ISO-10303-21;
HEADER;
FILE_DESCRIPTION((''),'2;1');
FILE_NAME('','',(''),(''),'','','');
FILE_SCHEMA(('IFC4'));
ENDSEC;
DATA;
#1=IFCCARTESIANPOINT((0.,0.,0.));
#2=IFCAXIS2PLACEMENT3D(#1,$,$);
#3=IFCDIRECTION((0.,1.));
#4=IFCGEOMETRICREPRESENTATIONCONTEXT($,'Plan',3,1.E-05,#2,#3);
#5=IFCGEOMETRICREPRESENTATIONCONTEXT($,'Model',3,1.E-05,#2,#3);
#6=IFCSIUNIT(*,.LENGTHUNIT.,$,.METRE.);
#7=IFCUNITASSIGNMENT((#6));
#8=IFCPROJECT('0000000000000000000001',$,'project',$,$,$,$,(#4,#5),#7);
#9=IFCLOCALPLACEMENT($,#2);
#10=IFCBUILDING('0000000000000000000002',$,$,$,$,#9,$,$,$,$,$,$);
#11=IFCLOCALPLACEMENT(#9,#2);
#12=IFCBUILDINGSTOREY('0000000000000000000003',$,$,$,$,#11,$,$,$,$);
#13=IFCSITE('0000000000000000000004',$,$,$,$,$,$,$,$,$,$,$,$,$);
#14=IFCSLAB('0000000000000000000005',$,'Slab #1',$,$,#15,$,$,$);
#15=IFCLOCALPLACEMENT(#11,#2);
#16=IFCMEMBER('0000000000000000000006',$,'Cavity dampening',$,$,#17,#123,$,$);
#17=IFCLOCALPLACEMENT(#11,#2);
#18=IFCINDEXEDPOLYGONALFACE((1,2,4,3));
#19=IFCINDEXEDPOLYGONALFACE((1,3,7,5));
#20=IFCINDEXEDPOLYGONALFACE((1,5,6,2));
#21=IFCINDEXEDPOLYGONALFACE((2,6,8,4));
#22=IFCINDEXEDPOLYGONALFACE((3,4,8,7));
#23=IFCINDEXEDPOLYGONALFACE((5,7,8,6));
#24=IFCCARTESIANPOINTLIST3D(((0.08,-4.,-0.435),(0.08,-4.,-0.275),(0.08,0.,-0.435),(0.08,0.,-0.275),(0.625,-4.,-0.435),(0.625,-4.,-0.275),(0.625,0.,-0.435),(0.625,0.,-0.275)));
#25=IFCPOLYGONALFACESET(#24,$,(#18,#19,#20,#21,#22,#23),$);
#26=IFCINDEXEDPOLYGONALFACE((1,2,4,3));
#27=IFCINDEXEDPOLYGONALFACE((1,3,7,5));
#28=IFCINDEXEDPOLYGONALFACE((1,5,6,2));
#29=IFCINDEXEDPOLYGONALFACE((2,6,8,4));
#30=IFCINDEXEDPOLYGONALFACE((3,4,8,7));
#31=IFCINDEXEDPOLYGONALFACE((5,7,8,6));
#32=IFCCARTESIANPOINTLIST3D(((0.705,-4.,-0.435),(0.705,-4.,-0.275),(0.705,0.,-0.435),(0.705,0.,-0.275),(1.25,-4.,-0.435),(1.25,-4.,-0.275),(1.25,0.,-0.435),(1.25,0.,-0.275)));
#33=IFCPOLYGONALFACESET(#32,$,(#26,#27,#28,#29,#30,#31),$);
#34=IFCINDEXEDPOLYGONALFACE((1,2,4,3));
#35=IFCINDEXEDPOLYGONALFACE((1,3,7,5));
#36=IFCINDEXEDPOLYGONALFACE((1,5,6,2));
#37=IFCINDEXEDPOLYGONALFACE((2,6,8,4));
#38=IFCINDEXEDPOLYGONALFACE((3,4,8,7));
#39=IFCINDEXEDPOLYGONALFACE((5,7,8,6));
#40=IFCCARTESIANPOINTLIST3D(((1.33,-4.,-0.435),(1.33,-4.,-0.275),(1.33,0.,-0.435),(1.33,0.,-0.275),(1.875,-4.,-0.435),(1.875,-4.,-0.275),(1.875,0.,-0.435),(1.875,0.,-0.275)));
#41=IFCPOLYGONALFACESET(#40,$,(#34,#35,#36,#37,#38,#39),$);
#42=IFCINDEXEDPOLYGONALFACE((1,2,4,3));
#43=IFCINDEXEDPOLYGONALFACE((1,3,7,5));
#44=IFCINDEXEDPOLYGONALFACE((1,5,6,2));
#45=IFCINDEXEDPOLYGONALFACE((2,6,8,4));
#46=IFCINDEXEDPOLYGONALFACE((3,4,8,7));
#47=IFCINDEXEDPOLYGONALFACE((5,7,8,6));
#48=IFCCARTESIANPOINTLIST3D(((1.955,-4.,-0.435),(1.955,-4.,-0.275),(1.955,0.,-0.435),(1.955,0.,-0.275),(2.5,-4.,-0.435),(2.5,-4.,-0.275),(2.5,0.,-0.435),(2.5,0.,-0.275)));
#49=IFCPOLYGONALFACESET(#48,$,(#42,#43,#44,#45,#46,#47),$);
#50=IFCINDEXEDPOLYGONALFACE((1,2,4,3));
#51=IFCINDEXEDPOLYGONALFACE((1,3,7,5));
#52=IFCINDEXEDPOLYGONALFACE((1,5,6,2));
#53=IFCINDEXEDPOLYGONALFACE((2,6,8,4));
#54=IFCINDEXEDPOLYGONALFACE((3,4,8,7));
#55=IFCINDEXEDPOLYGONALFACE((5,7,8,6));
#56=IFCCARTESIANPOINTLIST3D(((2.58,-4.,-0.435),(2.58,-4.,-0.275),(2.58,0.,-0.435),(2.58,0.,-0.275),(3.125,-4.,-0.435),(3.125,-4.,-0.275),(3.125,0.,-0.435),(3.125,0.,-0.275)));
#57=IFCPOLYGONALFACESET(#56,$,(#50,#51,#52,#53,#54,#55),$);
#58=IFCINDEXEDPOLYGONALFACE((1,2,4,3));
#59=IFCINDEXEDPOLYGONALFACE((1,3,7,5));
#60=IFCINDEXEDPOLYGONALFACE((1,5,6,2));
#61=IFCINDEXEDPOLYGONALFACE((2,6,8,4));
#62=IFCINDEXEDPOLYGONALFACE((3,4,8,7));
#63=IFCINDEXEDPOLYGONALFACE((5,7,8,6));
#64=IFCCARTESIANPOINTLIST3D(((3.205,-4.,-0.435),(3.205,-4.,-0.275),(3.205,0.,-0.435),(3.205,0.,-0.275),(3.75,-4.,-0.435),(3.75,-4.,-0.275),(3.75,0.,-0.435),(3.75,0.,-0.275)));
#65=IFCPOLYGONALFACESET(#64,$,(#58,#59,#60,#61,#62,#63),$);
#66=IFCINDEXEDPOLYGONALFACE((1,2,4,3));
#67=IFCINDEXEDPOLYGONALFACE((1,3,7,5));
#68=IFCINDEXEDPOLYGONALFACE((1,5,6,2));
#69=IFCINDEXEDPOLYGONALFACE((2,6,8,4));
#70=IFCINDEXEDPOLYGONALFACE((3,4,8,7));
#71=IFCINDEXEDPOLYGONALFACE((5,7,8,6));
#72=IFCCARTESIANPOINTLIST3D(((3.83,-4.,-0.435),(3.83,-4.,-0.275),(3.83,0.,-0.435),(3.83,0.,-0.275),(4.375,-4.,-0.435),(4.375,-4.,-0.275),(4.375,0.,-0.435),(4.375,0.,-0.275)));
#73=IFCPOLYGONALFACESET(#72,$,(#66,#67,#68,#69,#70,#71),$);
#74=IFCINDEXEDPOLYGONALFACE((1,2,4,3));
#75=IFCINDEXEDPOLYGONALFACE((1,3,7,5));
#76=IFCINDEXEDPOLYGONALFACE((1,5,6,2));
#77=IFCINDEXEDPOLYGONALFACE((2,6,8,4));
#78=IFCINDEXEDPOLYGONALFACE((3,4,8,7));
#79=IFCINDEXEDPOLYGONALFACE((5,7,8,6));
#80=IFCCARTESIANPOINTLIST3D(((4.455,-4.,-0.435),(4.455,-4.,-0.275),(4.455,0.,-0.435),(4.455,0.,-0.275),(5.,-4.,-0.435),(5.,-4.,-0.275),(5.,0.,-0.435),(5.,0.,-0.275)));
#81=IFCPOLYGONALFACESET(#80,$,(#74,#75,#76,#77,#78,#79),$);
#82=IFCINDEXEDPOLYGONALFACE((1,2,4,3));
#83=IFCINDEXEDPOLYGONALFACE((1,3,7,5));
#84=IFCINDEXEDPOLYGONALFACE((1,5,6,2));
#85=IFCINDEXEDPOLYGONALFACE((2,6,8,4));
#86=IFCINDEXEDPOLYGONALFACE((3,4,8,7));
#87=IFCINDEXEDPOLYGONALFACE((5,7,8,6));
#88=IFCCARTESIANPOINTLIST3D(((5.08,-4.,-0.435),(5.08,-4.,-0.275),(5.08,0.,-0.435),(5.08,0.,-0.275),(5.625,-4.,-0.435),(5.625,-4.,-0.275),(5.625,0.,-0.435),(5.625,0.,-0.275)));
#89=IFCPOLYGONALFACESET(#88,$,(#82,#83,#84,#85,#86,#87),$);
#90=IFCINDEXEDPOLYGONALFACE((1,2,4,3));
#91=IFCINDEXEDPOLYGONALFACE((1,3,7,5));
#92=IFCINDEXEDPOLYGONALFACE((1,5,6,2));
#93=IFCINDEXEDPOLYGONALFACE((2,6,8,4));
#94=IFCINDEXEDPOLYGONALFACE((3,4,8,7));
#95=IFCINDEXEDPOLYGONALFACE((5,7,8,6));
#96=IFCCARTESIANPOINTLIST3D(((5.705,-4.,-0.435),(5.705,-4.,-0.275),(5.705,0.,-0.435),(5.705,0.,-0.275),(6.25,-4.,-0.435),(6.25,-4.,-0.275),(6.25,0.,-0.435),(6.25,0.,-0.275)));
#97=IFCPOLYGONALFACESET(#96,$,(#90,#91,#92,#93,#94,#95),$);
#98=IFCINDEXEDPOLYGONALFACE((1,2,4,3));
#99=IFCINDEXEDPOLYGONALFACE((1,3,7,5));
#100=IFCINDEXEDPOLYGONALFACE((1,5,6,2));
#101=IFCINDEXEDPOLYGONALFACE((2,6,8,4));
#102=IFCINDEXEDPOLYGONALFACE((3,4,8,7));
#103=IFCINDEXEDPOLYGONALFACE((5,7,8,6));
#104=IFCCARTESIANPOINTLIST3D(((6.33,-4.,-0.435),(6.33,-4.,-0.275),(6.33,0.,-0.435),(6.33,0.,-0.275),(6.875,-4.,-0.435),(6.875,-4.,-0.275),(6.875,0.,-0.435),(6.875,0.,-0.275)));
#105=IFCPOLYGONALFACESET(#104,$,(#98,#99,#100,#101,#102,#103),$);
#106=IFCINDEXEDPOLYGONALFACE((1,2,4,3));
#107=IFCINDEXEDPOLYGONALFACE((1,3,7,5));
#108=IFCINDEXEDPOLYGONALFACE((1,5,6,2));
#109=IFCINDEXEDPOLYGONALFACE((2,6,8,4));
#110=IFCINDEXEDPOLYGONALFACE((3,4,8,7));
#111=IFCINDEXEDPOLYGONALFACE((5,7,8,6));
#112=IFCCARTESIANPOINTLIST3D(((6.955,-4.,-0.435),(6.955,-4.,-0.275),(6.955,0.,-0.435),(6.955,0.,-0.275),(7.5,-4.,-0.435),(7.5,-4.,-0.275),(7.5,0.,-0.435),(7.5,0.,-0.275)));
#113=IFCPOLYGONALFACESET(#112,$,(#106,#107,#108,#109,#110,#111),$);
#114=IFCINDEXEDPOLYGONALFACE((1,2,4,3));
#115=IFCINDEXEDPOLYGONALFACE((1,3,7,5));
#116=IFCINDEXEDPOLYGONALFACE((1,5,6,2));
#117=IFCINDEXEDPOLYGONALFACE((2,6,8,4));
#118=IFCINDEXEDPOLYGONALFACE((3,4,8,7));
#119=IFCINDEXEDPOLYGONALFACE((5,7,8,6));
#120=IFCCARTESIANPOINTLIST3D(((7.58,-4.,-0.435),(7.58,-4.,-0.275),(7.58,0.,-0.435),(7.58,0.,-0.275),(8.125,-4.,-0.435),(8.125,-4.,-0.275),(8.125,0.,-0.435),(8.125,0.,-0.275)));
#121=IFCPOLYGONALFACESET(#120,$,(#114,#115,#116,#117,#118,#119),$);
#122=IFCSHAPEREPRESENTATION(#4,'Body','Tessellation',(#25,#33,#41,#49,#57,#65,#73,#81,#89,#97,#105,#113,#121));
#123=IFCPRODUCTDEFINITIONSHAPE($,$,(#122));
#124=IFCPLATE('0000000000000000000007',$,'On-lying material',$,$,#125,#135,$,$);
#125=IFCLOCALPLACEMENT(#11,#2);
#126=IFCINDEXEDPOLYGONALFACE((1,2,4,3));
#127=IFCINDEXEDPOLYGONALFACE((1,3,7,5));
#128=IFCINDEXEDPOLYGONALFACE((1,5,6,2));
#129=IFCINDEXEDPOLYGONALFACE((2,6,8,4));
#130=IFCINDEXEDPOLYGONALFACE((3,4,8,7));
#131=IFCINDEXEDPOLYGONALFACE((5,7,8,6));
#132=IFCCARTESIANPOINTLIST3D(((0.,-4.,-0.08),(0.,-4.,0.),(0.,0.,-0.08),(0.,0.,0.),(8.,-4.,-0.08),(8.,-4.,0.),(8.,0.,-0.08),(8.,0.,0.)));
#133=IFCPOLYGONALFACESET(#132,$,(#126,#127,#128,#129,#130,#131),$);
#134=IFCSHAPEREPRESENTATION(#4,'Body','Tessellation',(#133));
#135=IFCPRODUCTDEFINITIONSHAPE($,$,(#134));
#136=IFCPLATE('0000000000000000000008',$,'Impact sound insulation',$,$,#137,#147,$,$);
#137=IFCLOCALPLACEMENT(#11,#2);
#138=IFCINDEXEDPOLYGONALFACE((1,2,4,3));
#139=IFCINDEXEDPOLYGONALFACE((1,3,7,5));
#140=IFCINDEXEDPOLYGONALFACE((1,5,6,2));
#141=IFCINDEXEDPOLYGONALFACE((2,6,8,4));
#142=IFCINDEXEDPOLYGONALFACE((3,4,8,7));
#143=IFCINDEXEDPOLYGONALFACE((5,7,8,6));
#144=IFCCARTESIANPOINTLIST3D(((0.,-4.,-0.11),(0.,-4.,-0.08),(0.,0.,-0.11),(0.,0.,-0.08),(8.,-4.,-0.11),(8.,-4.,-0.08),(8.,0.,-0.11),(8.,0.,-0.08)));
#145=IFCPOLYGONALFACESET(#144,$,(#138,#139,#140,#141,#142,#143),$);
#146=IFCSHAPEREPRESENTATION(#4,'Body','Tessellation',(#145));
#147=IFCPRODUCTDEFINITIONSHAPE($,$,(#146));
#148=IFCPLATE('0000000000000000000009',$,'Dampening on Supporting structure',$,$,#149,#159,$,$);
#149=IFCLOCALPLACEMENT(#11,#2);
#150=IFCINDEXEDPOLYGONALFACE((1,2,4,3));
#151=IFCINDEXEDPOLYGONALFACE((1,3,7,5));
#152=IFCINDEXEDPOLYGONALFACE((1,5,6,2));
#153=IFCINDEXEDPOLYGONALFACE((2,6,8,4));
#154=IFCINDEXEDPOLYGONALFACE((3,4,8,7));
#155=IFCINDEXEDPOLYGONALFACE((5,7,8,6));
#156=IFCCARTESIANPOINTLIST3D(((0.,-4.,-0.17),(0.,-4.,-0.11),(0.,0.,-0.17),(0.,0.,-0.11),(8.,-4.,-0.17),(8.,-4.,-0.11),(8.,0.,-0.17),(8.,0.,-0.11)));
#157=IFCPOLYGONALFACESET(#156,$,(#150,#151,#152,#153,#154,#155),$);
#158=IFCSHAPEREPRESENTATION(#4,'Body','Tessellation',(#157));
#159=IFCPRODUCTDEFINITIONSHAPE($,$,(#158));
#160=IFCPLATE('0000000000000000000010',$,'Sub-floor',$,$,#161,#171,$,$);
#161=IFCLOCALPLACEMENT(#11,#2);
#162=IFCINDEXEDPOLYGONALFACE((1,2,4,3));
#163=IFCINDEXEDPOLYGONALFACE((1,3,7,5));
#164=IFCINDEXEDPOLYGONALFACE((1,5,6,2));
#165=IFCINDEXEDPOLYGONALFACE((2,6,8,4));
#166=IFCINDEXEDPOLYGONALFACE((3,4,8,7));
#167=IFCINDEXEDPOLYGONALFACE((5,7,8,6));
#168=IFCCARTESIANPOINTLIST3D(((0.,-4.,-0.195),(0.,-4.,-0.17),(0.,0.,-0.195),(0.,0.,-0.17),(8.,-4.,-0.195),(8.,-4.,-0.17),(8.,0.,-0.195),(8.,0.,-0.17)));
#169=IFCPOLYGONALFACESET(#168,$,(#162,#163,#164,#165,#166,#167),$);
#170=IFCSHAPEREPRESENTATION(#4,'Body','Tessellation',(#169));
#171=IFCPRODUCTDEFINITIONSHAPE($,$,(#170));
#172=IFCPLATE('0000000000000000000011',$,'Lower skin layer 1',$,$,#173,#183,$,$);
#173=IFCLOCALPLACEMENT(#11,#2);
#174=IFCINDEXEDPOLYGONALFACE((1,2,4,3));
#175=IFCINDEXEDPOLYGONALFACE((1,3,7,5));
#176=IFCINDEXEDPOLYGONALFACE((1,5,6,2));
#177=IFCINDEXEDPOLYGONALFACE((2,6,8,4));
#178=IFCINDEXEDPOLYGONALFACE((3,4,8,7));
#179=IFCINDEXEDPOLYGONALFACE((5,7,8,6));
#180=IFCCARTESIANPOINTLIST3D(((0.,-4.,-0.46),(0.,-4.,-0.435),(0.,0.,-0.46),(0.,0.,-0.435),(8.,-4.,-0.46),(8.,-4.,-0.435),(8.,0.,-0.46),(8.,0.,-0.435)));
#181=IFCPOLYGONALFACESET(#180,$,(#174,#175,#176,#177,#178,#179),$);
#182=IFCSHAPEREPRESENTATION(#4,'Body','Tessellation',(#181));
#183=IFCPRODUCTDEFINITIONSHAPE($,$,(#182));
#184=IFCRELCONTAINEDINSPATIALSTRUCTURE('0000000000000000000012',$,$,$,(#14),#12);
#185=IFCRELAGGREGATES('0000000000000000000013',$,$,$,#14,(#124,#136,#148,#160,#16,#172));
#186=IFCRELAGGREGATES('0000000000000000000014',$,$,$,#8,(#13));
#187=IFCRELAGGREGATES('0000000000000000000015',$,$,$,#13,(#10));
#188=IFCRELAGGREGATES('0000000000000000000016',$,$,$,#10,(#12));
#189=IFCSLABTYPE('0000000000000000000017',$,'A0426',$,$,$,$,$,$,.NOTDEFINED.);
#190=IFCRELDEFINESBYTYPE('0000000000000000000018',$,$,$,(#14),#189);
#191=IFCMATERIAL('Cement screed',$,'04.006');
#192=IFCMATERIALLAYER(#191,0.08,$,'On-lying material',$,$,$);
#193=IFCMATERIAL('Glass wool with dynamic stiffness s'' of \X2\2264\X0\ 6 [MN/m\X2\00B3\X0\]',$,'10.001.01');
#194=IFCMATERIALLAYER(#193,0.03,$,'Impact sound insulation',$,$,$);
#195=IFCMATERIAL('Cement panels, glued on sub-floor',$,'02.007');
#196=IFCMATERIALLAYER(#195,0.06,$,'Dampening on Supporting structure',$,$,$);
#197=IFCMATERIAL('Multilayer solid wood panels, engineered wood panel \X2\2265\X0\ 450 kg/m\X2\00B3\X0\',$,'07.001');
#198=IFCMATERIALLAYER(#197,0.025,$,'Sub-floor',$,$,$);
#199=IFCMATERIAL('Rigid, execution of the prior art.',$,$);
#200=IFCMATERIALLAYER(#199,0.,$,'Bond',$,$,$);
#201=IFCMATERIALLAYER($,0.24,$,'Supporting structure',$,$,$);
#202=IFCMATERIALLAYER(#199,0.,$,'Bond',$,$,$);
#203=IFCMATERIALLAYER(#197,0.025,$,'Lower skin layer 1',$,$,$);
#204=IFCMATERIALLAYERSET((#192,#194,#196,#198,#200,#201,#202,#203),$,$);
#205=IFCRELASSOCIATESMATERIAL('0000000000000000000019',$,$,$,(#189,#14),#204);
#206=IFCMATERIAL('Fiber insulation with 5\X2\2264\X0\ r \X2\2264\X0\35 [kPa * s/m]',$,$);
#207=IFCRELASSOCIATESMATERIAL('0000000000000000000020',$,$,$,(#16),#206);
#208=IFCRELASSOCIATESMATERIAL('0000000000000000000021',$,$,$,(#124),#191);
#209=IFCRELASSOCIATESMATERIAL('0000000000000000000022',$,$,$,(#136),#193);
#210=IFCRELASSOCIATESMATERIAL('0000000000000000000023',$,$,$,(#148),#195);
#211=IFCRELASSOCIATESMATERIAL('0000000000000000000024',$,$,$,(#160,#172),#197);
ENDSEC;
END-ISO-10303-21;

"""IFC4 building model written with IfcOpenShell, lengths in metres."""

from ifc_helpers import new_model, si_unit, direction, frame, frame_2d, origin, origin_with_axes, place, context, project, spatial, rectangle, extrude, material, layer, layer_set, type_object, element, aggregate, save


model = new_model("IFC4")

# Units and contexts
plan_context = context("Plan", 3, precision=1e-05, world=origin(), true_north=direction((0.0, 1.0)))
model_context = context("Model", 3, precision=1e-05, world=origin(), true_north=direction((0.0, 1.0)))
ifc_project = project(units=[si_unit("LENGTHUNIT", "METRE")], contexts=[plan_context, model_context])

# Site, building, storey
site = spatial("IfcSite", under=ifc_project)
building_placement = place(None, origin())
building = spatial("IfcBuilding", under=site, at=building_placement)
storey_placement = place(building_placement, origin())
storey = spatial("IfcBuildingStorey", under=building, at=storey_placement)

# Slab, member, plates
ifc_material_1 = material(Name="Cement screed", Category="04.006")
ifc_layer_1 = layer(ifc_material_1, 0.08, Name="On-lying material")
ifc_material_2 = material(Name="Glass wool with dynamic stiffness s' of ≤ 6 [MN/m³]", Category="10.001.01")
ifc_layer_2 = layer(ifc_material_2, 0.03, Name="Impact sound insulation")
ifc_material_3 = material(Name="Cement panels, glued on sub-floor", Category="02.007")
ifc_layer_3 = layer(ifc_material_3, 0.06, Name="Dampening on Supporting structure")
ifc_material_4 = material(Name="Multilayer solid wood panels, engineered wood panel ≥ 450 kg/m³", Category="07.001")
ifc_layer_4 = layer(ifc_material_4, 0.025, Name="Sub-floor")
ifc_material_5 = material(Name="Rigid, execution of the prior art.")
ifc_layer_5 = layer(ifc_material_5, 0.0, Name="Bond")
ifc_layer_6 = layer(None, 0.24, Name="Supporting structure")
ifc_layer_7 = layer(ifc_material_5, 0.0, Name="Bond")
ifc_layer_8 = layer(ifc_material_4, 0.025, Name="Lower skin layer 1")
ifc_layer_set = layer_set([ifc_layer_1, ifc_layer_2, ifc_layer_3, ifc_layer_4, ifc_layer_5, ifc_layer_6, ifc_layer_7, ifc_layer_8])
slab_type = type_object("IfcSlabType", Name="A0426", PredefinedType="NOTDEFINED", material=ifc_layer_set)
slab_placement = place(None, frame((0.0, 0.0, 0.0), z_axis=(0.0, 0.0, -1.0), x_axis=(1.0, 0.0, 0.0)))
slab = element("IfcSlab", 1, at=slab_placement, inside=storey, type_object=slab_type, material=ifc_layer_set, Name="Slab #1")
ifc_material_6 = material(Name="Fiber insulation with 5≤ r ≤35 [kPa * s/m]")
member_1_placement = place(slab_placement, origin())
member_1 = element("IfcMember", 2, at=member_1_placement, material=ifc_material_6, Name="Cavity dampening", context=plan_context, shape_type="SweptSolid", body=[
    extrude(rectangle(XDim=0.545, YDim=0.16, at=frame_2d((0.2725, 0.08), x_axis=(1.0, 0.0))), frame((0.08, 4.0, 0.275), z_axis=(0.0, -1.0, 0.0), x_axis=(1.0, 0.0, 0.0)), (0.0, 0.0, 1.0), 4.0),
    extrude(rectangle(XDim=0.545, YDim=0.16, at=frame_2d((0.2725, 0.08), x_axis=(1.0, 0.0))), frame((0.705, 4.0, 0.275), z_axis=(0.0, -1.0, 0.0), x_axis=(1.0, 0.0, 0.0)), (0.0, 0.0, 1.0), 4.0),
    extrude(rectangle(XDim=0.545, YDim=0.16, at=frame_2d((0.2725, 0.08), x_axis=(1.0, 0.0))), frame((1.33, 4.0, 0.275), z_axis=(0.0, -1.0, 0.0), x_axis=(1.0, 0.0, 0.0)), (0.0, 0.0, 1.0), 4.0),
    extrude(rectangle(XDim=0.545, YDim=0.16, at=frame_2d((0.2725, 0.08), x_axis=(1.0, 0.0))), frame((1.955, 4.0, 0.275), z_axis=(0.0, -1.0, 0.0), x_axis=(1.0, 0.0, 0.0)), (0.0, 0.0, 1.0), 4.0),
    extrude(rectangle(XDim=0.545, YDim=0.16, at=frame_2d((0.2725, 0.08), x_axis=(1.0, 0.0))), frame((2.58, 4.0, 0.275), z_axis=(0.0, -1.0, 0.0), x_axis=(1.0, 0.0, 0.0)), (0.0, 0.0, 1.0), 4.0),
    extrude(rectangle(XDim=0.545, YDim=0.16, at=frame_2d((0.2725, 0.08), x_axis=(1.0, 0.0))), frame((3.205, 4.0, 0.275), z_axis=(0.0, -1.0, 0.0), x_axis=(1.0, 0.0, 0.0)), (0.0, 0.0, 1.0), 4.0),
    extrude(rectangle(XDim=0.545, YDim=0.16, at=frame_2d((0.2725, 0.08), x_axis=(1.0, 0.0))), frame((3.83, 4.0, 0.275), z_axis=(0.0, -1.0, 0.0), x_axis=(1.0, 0.0, 0.0)), (0.0, 0.0, 1.0), 4.0),
    extrude(rectangle(XDim=0.545, YDim=0.16, at=frame_2d((0.2725, 0.08), x_axis=(1.0, 0.0))), frame((4.455, 4.0, 0.275), z_axis=(0.0, -1.0, 0.0), x_axis=(1.0, 0.0, 0.0)), (0.0, 0.0, 1.0), 4.0),
    extrude(rectangle(XDim=0.545, YDim=0.16, at=frame_2d((0.2725, 0.08), x_axis=(1.0, 0.0))), frame((5.08, 4.0, 0.275), z_axis=(0.0, -1.0, 0.0), x_axis=(1.0, 0.0, 0.0)), (0.0, 0.0, 1.0), 4.0),
    extrude(rectangle(XDim=0.545, YDim=0.16, at=frame_2d((0.2725, 0.08), x_axis=(1.0, 0.0))), frame((5.705, 4.0, 0.275), z_axis=(0.0, -1.0, 0.0), x_axis=(1.0, 0.0, 0.0)), (0.0, 0.0, 1.0), 4.0),
    extrude(rectangle(XDim=0.545, YDim=0.16, at=frame_2d((0.2725, 0.08), x_axis=(1.0, 0.0))), frame((6.33, 4.0, 0.275), z_axis=(0.0, -1.0, 0.0), x_axis=(1.0, 0.0, 0.0)), (0.0, 0.0, 1.0), 4.0),
    extrude(rectangle(XDim=0.545, YDim=0.16, at=frame_2d((0.2725, 0.08), x_axis=(1.0, 0.0))), frame((6.955, 4.0, 0.275), z_axis=(0.0, -1.0, 0.0), x_axis=(1.0, 0.0, 0.0)), (0.0, 0.0, 1.0), 4.0),
    extrude(rectangle(XDim=0.545, YDim=0.16, at=frame_2d((0.2725, 0.08), x_axis=(1.0, 0.0))), frame((7.58, 4.0, 0.275), z_axis=(0.0, -1.0, 0.0), x_axis=(1.0, 0.0, 0.0)), (0.0, 0.0, 1.0), 4.0),
])
plate_1_placement = place(slab_placement, origin())
plate_1 = element("IfcPlate", 3, at=plate_1_placement, material=ifc_material_1, Name="On-lying material", context=plan_context, shape_type="SweptSolid", body=[
    extrude(rectangle(XDim=8.0, YDim=4.0, at=frame_2d((4.0, 2.0), x_axis=(1.0, 0.0))), origin_with_axes(), (0.0, 0.0, 1.0), 0.08),
])
plate_2_placement = place(slab_placement, origin())
plate_2 = element("IfcPlate", 4, at=plate_2_placement, material=ifc_material_2, Name="Impact sound insulation", context=plan_context, shape_type="SweptSolid", body=[
    extrude(rectangle(XDim=8.0, YDim=4.0, at=frame_2d((4.0, 2.0), x_axis=(1.0, 0.0))), frame((0.0, 0.0, 0.08), z_axis=(0.0, 0.0, 1.0), x_axis=(1.0, 0.0, 0.0)), (0.0, 0.0, 1.0), 0.03),
])
plate_3_placement = place(slab_placement, origin())
plate_3 = element("IfcPlate", 5, at=plate_3_placement, material=ifc_material_3, Name="Dampening on Supporting structure", context=plan_context, shape_type="SweptSolid", body=[
    extrude(rectangle(XDim=8.0, YDim=4.0, at=frame_2d((4.0, 2.0), x_axis=(1.0, 0.0))), frame((0.0, 0.0, 0.11), z_axis=(0.0, 0.0, 1.0), x_axis=(1.0, 0.0, 0.0)), (0.0, 0.0, 1.0), 0.06),
])
plate_4_placement = place(slab_placement, origin())
plate_4 = element("IfcPlate", 6, at=plate_4_placement, material=ifc_material_4, Name="Sub-floor", context=plan_context, shape_type="SweptSolid", body=[
    extrude(rectangle(XDim=8.0, YDim=4.0, at=frame_2d((4.0, 2.0), x_axis=(1.0, 0.0))), frame((0.0, 0.0, 0.17), z_axis=(0.0, 0.0, 1.0), x_axis=(1.0, 0.0, 0.0)), (0.0, 0.0, 1.0), 0.025),
])
plate_5_placement = place(slab_placement, origin())
plate_5 = element("IfcPlate", 7, at=plate_5_placement, material=ifc_material_4, Name="Lower skin layer 1", context=plan_context, shape_type="SweptSolid", body=[
    extrude(rectangle(XDim=8.0, YDim=4.0, at=frame_2d((4.0, 2.0), x_axis=(1.0, 0.0))), frame((0.0, 0.0, 0.435), z_axis=(0.0, 0.0, 1.0), x_axis=(1.0, 0.0, 0.0)), (0.0, 0.0, 1.0), 0.025),
])
aggregate(slab, [plate_1, plate_2, plate_3, plate_4, member_1, plate_5])

save(model, "model.ifc")
